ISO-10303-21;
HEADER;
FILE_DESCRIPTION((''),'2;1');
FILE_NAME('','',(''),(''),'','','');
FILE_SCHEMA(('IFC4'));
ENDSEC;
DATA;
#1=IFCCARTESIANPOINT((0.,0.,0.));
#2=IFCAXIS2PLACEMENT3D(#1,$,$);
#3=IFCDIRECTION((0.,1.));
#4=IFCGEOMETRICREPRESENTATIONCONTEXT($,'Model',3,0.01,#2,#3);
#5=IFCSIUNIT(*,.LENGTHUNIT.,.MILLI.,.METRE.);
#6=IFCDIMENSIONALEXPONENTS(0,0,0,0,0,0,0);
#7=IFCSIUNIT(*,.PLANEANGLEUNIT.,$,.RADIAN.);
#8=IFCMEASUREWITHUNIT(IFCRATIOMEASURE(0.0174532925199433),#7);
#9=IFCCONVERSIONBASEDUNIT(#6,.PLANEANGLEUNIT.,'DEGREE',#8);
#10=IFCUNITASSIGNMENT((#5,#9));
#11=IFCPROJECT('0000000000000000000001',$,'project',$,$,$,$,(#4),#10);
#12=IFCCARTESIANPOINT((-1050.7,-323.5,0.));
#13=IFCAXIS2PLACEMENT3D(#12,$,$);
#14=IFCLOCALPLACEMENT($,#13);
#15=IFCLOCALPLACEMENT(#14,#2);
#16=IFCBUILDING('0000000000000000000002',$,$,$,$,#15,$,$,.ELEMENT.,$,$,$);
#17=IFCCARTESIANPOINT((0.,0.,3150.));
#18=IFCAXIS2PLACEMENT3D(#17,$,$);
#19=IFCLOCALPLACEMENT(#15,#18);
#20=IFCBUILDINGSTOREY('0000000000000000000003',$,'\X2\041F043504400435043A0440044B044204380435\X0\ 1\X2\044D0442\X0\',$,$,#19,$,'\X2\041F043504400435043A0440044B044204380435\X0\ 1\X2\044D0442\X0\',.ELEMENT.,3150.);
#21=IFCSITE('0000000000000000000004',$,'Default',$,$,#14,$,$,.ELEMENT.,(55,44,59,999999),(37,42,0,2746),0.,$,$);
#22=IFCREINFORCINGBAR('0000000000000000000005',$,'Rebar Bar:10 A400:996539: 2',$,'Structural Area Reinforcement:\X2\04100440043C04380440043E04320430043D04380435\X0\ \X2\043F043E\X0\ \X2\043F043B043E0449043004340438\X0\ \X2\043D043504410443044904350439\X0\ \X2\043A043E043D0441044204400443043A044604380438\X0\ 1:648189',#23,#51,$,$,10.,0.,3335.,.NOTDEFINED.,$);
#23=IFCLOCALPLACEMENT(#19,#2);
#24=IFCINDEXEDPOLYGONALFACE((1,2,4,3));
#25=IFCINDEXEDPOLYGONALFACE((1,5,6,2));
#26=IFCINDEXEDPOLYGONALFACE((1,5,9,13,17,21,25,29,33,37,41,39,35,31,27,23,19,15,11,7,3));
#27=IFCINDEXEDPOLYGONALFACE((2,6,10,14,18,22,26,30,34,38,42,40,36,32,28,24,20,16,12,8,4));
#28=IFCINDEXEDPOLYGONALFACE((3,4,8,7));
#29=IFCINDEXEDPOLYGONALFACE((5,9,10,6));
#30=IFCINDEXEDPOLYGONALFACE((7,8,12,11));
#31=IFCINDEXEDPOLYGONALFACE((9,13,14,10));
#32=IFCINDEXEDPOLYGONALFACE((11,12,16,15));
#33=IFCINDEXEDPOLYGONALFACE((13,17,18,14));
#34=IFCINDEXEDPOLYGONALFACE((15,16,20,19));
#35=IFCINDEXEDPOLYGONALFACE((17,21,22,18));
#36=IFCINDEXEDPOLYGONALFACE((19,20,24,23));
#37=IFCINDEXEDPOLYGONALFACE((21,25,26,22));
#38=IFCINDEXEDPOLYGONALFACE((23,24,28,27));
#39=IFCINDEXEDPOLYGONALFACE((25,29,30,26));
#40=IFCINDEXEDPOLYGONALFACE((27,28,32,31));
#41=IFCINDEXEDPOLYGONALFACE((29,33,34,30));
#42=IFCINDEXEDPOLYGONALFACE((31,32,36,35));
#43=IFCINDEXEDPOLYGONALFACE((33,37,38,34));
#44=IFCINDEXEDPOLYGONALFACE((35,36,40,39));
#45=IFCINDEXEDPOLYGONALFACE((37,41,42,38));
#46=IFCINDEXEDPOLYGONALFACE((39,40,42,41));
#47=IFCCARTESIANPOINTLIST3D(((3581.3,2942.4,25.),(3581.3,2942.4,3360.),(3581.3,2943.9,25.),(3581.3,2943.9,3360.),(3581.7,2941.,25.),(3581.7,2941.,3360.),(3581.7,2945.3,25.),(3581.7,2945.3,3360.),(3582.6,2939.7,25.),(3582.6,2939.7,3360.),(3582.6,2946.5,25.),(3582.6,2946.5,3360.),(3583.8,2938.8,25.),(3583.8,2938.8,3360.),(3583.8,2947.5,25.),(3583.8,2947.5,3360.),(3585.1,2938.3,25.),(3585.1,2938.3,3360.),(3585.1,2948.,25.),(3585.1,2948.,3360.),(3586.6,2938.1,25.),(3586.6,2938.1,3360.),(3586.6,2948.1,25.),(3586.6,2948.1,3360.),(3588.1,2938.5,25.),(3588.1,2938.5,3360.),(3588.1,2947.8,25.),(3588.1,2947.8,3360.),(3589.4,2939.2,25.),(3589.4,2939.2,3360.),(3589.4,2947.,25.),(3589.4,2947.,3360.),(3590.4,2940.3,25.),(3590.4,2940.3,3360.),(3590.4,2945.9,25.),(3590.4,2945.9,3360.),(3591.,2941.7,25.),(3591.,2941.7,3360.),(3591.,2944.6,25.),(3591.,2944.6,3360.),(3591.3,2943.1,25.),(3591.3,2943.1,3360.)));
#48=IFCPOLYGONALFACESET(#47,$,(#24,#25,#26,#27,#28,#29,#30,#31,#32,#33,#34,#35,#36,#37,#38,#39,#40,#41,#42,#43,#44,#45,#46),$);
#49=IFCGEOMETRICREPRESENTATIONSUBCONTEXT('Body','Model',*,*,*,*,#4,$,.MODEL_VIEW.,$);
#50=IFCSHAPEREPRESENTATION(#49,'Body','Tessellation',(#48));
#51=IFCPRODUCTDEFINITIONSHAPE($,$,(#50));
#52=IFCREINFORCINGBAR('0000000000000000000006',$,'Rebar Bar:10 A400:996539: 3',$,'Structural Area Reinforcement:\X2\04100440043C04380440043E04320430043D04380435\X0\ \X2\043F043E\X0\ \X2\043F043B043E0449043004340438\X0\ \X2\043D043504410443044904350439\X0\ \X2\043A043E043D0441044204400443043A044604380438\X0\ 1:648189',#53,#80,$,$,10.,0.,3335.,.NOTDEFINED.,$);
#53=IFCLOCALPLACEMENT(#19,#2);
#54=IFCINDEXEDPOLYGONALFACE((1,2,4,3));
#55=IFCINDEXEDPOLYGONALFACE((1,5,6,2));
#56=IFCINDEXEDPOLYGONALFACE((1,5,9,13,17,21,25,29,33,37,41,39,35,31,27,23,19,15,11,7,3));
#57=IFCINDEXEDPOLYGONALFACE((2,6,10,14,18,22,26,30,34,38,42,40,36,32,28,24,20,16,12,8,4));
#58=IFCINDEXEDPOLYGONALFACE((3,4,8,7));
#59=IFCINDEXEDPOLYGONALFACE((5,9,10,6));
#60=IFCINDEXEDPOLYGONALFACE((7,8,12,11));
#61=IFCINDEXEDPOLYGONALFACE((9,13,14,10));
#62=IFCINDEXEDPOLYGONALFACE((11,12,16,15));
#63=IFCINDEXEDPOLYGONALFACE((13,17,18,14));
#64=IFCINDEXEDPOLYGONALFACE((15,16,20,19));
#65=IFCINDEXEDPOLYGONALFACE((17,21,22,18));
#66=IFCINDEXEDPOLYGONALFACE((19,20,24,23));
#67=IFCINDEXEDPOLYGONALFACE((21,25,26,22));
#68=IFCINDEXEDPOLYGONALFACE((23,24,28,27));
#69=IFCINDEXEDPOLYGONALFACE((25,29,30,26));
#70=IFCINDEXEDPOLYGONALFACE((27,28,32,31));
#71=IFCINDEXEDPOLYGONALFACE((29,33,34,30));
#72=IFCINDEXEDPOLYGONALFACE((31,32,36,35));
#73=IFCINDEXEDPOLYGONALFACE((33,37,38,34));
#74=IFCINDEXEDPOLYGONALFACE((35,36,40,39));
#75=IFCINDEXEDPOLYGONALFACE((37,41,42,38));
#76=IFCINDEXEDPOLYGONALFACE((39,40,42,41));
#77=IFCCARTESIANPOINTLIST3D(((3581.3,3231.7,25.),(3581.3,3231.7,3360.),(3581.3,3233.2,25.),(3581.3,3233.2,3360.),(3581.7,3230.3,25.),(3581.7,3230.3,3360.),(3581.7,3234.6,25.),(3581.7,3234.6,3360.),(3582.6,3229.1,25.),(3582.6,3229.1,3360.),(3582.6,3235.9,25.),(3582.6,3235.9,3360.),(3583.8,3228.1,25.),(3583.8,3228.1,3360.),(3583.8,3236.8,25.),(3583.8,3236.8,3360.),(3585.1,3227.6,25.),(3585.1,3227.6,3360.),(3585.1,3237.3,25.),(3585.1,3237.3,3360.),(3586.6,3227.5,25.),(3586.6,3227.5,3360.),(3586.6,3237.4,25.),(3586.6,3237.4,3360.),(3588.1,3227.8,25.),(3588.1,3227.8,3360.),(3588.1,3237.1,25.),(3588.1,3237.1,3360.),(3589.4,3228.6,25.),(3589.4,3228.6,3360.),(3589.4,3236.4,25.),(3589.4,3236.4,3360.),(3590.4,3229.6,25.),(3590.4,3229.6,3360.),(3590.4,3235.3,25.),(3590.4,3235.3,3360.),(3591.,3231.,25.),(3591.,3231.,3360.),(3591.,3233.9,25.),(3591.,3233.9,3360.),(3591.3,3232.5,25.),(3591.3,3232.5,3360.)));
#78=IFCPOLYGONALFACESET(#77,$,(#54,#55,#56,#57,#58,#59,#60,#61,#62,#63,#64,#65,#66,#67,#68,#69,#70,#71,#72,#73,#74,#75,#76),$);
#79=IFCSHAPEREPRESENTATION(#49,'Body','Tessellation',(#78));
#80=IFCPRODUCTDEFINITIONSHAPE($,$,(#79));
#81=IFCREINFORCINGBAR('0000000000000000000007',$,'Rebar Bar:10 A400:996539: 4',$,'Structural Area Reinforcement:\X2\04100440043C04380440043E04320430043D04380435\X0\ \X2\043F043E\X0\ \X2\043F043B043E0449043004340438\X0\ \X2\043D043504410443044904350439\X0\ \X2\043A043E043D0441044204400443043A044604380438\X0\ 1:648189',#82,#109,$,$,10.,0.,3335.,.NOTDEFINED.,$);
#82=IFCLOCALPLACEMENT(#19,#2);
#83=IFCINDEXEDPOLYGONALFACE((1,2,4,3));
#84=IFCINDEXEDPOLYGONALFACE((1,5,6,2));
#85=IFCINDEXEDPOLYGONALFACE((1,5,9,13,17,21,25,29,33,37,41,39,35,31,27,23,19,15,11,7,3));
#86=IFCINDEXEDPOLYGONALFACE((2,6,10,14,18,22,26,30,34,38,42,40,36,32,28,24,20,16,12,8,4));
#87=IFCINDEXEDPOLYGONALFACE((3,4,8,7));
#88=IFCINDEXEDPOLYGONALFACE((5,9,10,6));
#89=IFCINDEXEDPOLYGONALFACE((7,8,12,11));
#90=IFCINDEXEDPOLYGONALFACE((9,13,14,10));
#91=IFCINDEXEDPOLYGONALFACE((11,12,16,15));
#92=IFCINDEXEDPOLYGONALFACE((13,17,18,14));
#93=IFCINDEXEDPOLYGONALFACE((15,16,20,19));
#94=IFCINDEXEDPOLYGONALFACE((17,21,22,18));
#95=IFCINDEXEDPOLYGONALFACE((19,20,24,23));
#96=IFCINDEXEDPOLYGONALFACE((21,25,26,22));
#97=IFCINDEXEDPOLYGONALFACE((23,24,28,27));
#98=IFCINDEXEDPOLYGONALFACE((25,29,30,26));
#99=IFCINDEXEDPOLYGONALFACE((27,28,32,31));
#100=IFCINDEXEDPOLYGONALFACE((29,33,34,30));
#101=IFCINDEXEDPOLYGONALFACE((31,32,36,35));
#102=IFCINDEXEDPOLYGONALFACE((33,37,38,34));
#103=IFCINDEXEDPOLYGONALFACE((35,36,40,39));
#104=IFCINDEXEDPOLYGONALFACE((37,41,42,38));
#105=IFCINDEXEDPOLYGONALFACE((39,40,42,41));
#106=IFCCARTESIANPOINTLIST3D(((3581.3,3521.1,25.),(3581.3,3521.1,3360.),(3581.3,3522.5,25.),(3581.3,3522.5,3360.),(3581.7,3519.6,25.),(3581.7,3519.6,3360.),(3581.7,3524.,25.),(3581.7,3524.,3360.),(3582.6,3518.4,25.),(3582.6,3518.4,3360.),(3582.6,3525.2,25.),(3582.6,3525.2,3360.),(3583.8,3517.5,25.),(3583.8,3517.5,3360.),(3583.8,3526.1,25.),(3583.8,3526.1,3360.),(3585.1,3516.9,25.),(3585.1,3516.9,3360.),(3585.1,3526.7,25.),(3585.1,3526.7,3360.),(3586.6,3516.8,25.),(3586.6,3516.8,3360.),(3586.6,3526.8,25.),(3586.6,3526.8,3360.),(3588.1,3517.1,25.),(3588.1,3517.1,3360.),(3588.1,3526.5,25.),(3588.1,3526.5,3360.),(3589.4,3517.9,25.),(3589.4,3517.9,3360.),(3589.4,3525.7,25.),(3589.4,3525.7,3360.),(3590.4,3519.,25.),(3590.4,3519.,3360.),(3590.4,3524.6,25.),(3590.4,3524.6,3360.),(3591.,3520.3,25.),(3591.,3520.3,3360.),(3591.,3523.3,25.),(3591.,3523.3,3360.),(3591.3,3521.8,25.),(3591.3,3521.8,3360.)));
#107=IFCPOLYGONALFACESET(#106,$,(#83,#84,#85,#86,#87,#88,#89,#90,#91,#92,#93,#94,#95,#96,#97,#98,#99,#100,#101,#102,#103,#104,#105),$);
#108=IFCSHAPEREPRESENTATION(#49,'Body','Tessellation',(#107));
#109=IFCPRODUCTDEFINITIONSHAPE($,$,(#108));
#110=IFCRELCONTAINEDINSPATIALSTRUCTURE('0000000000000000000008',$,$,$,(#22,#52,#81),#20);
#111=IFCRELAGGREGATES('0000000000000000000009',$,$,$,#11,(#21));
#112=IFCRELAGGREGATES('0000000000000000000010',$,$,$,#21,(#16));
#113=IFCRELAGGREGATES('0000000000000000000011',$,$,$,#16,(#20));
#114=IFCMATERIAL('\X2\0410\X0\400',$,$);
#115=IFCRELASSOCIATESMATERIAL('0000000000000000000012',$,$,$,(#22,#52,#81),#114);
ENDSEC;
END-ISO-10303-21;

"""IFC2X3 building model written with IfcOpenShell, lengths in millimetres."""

from ifc_helpers import new_model, entity, si_unit, converted_unit, direction, frame, origin, place, context, subcontext, project, spatial, material, element, save


model = new_model("IFC2X3")

# Units and contexts
model_context = context("Model", 3, precision=0.01, world=origin(), true_north=direction((0.0, 1.0)))
body_context = subcontext(model_context, "Body", "Model", "MODEL_VIEW")
ifc_project = project(units=[si_unit("LENGTHUNIT", "METRE", prefix="MILLI"), converted_unit("PLANEANGLEUNIT", "DEGREE", entity("IfcRatioMeasure", 0.0174532925199433), si_unit("PLANEANGLEUNIT", "RADIAN"), dimensions=[0, 0, 0, 0, 0, 0, 0])], contexts=[model_context])

# Site, building, storey
site_placement = place(None, frame((-1050.7, -323.5, 0.0)))
site = spatial("IfcSite", under=ifc_project, at=site_placement, Name="Default", CompositionType="ELEMENT", RefLatitude=(55, 44, 59, 999999), RefLongitude=(37, 42, 0, 2746), RefElevation=0.0)
building_placement = place(site_placement, origin())
building = spatial("IfcBuilding", under=site, at=building_placement, CompositionType="ELEMENT")
storey_placement = place(building_placement, frame((0.0, 0.0, 3150.0)))
storey = spatial("IfcBuildingStorey", under=building, at=storey_placement, Name="Перекрытие 1эт", LongName="Перекрытие 1эт", CompositionType="ELEMENT", Elevation=3150.0)

# Reinforcing bars
ifc_material = material(Name="А400")
reinforcing_bar_1_placement = place(storey_placement, origin())
element("IfcReinforcingBar", 1, at=reinforcing_bar_1_placement, inside=storey, material=ifc_material, Name="Rebar Bar:10 A400:996539: 2", ObjectType="Structural Area Reinforcement:Армирование по площади несущей конструкции 1:648189", BarLength=3335.0, BarRole="NOTDEFINED", CrossSectionArea=0.0, NominalDiameter=10.0, context=body_context, shape_type="AdvancedSweptSolid", body=[
    entity("IfcSweptDiskSolid", entity("IfcCompositeCurve", [entity("IfcCompositeCurveSegment", "CONTINUOUS", True, entity("IfcPolyline", [entity("IfcCartesianPoint", [3586.3, 2943.1, 25.0]), entity("IfcCartesianPoint", [3586.3, 2943.1, 3360.0])]))], False), 5.0, None, 0.0, 1.0),
])
reinforcing_bar_2_placement = place(storey_placement, origin())
element("IfcReinforcingBar", 2, at=reinforcing_bar_2_placement, inside=storey, material=ifc_material, Name="Rebar Bar:10 A400:996539: 3", ObjectType="Structural Area Reinforcement:Армирование по площади несущей конструкции 1:648189", BarLength=3335.0, BarRole="NOTDEFINED", CrossSectionArea=0.0, NominalDiameter=10.0, context=body_context, shape_type="AdvancedSweptSolid", body=[
    entity("IfcSweptDiskSolid", entity("IfcCompositeCurve", [entity("IfcCompositeCurveSegment", "CONTINUOUS", True, entity("IfcPolyline", [entity("IfcCartesianPoint", [3586.3, 3232.5, 25.0]), entity("IfcCartesianPoint", [3586.3, 3232.5, 3360.0])]))], False), 5.0, None, 0.0, 1.0),
])
reinforcing_bar_3_placement = place(storey_placement, origin())
element("IfcReinforcingBar", 3, at=reinforcing_bar_3_placement, inside=storey, material=ifc_material, Name="Rebar Bar:10 A400:996539: 4", ObjectType="Structural Area Reinforcement:Армирование по площади несущей конструкции 1:648189", BarLength=3335.0, BarRole="NOTDEFINED", CrossSectionArea=0.0, NominalDiameter=10.0, context=body_context, shape_type="AdvancedSweptSolid", body=[
    entity("IfcSweptDiskSolid", entity("IfcCompositeCurve", [entity("IfcCompositeCurveSegment", "CONTINUOUS", True, entity("IfcPolyline", [entity("IfcCartesianPoint", [3586.3, 3521.8, 25.0]), entity("IfcCartesianPoint", [3586.3, 3521.8, 3360.0])]))], False), 5.0, None, 0.0, 1.0),
])

save(model, "model.ifc")
